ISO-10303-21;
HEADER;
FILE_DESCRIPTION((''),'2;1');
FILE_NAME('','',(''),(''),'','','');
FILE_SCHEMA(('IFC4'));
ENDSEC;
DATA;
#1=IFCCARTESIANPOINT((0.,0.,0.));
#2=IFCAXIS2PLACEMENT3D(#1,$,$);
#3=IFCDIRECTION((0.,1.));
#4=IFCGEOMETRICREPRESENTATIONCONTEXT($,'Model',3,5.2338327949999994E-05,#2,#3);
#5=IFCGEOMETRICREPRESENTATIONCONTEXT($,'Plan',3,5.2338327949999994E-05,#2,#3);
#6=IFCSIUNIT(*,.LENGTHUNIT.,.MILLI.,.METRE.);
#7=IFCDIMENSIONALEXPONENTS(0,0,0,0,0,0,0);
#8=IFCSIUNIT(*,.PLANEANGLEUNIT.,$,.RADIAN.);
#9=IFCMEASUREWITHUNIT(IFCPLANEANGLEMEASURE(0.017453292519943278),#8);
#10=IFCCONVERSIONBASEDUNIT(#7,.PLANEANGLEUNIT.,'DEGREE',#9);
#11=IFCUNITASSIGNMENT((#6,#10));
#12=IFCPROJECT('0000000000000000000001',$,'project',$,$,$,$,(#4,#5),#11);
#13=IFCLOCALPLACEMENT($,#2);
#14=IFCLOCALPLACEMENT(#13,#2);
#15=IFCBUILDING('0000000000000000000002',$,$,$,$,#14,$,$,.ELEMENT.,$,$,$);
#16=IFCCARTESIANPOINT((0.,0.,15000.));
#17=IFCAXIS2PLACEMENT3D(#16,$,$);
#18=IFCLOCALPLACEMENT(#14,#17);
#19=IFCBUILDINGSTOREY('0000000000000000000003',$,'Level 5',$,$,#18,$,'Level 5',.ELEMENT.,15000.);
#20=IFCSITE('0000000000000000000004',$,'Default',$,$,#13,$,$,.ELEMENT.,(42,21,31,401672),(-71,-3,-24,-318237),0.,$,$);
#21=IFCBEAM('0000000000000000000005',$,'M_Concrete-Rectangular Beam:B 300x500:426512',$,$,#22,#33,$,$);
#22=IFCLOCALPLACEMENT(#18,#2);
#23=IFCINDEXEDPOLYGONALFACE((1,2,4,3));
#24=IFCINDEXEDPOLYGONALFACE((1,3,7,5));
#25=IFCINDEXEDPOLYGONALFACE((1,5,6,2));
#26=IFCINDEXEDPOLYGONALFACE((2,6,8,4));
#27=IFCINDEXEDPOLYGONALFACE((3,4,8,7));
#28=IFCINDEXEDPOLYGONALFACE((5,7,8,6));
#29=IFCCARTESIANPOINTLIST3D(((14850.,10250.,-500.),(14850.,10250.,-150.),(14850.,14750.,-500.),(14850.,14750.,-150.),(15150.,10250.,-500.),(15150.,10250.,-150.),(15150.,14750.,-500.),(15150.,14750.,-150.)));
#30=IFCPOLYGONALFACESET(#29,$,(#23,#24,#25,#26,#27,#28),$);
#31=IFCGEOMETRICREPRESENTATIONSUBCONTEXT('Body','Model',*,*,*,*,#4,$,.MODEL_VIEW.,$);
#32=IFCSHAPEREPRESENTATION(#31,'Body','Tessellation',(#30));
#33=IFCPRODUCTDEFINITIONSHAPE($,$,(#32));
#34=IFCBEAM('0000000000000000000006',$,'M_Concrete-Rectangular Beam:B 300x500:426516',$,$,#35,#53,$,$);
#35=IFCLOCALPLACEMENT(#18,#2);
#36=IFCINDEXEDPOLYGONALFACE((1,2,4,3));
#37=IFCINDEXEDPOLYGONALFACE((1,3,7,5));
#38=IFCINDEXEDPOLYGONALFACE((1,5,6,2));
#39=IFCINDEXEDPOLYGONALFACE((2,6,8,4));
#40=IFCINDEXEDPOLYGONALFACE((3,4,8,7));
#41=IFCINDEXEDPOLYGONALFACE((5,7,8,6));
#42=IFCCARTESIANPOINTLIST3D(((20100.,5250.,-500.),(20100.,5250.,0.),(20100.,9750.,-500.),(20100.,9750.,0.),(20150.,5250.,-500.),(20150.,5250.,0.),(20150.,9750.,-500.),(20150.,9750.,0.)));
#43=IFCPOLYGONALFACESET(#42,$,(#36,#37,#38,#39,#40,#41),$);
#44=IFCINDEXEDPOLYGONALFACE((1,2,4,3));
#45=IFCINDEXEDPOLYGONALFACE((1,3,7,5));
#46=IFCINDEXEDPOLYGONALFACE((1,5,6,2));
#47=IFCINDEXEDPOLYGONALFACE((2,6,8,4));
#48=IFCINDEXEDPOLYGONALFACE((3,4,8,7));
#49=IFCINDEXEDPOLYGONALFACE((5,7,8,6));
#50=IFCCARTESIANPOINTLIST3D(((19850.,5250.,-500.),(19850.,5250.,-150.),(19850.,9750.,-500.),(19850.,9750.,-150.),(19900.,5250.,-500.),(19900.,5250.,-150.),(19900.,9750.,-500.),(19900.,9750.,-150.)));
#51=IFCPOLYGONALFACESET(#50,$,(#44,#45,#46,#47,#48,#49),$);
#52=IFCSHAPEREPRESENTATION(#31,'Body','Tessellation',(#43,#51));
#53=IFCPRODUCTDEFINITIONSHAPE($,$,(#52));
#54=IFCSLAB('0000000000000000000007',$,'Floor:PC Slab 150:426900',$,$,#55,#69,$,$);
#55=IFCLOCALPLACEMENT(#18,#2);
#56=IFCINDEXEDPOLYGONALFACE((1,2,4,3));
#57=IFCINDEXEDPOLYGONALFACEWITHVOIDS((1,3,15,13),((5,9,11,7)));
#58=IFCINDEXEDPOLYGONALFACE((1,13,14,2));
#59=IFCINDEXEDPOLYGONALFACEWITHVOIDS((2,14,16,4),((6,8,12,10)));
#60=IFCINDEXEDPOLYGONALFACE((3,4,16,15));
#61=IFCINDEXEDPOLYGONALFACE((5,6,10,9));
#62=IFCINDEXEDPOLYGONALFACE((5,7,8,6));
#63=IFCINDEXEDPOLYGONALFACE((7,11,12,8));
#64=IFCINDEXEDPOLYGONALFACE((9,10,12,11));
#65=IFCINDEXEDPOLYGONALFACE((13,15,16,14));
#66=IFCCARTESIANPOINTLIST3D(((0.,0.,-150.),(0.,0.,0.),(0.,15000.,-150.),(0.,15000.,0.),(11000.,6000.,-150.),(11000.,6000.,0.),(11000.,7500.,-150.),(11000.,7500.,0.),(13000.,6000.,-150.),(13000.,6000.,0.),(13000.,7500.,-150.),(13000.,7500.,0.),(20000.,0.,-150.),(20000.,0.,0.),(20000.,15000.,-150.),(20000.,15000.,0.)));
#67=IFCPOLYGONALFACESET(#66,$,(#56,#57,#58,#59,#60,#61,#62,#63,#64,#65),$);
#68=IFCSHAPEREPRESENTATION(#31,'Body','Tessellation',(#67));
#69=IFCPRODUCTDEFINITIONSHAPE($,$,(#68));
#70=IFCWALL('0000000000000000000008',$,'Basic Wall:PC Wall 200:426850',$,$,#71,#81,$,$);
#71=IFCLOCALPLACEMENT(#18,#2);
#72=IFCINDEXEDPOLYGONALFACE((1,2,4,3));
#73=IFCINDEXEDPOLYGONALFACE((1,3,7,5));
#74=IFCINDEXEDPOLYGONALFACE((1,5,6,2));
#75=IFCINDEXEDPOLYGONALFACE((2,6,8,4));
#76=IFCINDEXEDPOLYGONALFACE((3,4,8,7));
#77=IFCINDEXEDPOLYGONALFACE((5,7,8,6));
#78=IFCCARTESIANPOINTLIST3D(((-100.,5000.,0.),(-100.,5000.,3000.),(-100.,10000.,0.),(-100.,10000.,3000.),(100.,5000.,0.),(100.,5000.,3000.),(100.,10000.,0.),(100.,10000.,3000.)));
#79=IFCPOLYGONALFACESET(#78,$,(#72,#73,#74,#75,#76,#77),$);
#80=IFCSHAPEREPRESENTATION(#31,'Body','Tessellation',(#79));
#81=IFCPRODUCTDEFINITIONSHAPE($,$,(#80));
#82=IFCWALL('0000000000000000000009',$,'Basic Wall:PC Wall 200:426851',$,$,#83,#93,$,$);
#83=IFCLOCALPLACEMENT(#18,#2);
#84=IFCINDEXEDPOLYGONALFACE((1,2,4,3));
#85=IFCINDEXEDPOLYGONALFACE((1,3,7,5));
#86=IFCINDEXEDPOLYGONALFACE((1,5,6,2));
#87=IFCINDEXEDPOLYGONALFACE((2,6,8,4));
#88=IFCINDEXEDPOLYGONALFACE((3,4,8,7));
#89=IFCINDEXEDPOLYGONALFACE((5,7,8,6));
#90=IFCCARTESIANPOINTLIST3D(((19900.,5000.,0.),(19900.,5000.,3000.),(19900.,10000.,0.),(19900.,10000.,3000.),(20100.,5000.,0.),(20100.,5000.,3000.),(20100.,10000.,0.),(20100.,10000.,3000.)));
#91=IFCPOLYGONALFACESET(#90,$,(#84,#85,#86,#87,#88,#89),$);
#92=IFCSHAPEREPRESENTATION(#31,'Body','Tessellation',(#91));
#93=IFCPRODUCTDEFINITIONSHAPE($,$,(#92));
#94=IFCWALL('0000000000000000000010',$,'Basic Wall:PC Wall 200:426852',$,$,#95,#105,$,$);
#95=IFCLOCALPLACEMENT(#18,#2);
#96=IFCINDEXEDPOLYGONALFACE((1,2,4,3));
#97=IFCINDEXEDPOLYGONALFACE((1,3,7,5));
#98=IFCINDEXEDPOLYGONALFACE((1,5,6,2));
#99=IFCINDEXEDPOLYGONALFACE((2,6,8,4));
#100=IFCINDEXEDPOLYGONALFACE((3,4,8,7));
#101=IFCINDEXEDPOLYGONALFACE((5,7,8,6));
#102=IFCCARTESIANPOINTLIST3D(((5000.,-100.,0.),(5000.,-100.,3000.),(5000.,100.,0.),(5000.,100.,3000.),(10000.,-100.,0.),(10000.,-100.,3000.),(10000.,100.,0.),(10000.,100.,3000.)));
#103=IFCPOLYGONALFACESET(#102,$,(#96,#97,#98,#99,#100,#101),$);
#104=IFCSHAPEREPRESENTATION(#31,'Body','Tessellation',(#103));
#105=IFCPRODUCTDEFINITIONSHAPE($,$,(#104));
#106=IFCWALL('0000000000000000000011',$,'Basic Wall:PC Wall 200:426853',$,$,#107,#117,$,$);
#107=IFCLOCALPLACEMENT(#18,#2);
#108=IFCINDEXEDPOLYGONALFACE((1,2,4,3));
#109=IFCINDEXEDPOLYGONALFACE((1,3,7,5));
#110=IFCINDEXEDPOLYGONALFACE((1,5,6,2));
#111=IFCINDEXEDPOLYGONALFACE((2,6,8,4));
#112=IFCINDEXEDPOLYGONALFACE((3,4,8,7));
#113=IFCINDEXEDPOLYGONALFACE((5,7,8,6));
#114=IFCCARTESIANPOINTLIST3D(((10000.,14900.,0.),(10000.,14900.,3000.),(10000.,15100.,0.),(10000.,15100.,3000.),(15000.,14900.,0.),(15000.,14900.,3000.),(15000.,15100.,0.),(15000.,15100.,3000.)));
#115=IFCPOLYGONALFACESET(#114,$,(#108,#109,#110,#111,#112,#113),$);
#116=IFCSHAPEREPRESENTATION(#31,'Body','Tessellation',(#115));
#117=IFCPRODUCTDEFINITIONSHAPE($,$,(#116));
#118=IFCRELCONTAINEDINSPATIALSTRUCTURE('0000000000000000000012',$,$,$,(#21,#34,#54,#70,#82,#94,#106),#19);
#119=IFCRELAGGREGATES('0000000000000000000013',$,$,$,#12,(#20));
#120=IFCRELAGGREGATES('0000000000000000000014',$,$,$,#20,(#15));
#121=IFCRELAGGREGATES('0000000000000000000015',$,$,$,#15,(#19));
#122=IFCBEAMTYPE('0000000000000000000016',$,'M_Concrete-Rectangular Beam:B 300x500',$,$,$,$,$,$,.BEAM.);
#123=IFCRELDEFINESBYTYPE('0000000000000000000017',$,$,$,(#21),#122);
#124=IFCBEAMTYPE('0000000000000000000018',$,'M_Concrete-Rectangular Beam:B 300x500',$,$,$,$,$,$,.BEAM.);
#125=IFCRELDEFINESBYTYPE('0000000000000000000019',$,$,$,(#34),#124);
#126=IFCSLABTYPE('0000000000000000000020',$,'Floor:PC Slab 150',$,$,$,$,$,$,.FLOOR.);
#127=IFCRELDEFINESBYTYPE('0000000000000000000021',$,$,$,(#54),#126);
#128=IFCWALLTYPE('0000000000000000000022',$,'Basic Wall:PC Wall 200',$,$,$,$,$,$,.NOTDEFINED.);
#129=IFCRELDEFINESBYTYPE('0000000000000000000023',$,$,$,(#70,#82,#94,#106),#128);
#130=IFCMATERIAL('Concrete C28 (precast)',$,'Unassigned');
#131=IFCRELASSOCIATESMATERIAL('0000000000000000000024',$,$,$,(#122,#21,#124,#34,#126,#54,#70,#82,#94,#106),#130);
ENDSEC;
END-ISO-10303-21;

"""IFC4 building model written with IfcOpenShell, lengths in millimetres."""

from ifc_helpers import new_model, entity, si_unit, converted_unit, direction, frame, origin, place, context, subcontext, project, spatial, indexed_curve, outline, extrude, source, transform, mapped, material, type_object, type_shapes, element, save


model = new_model("IFC4")

# Units and contexts
model_context = context("Model", 3, precision=5.2338327949999994e-05, world=origin(), true_north=direction((0.0, 1.0)))
plan_context = context("Plan", 3, precision=5.2338327949999994e-05, world=origin(), true_north=direction((0.0, 1.0)))
body_context = subcontext(model_context, "Body", "Model", "MODEL_VIEW")
ifc_project = project(units=[si_unit("LENGTHUNIT", "METRE", prefix="MILLI"), converted_unit("PLANEANGLEUNIT", "DEGREE", entity("IfcPlaneAngleMeasure", 0.017453292519943278), si_unit("PLANEANGLEUNIT", "RADIAN"), dimensions=[0, 0, 0, 0, 0, 0, 0])], contexts=[model_context, plan_context])

# Site, building, storey
site_placement = place(None, origin())
site = spatial("IfcSite", under=ifc_project, at=site_placement, Name="Default", CompositionType="ELEMENT", RefLatitude=(42, 21, 31, 401672), RefLongitude=(-71, -3, -24, -318237), RefElevation=0.0)
building_placement = place(site_placement, origin())
building = spatial("IfcBuilding", under=site, at=building_placement, CompositionType="ELEMENT")
storey_placement = place(building_placement, frame((0.0, 0.0, 15000.0)))
storey = spatial("IfcBuildingStorey", under=building, at=storey_placement, Name="Level 5", LongName="Level 5", CompositionType="ELEMENT", Elevation=15000.0)

# Beams
ifc_material = material(Name="Concrete C28 (precast)", Category="Unassigned")
beam_type_1 = type_object("IfcBeamType", Name="M_Concrete-Rectangular Beam:B 300x500", PredefinedType="BEAM", material=ifc_material)
shared_shape_1 = source(origin(), body_context, "Body", "SweptSolid", [
    extrude(outline(indexed_curve([(-150.0, -175.0), (150.0, -175.0), (150.0, 175.0), (-150.0, 175.0), (-150.0, -175.0)], self_intersect=False)), frame((15000.0, 10250.0, 14675.0), z_axis=(0.0, 1.0, 0.0), x_axis=(-1.0, 0.0, 0.0)), (0.0, 0.0, 1.0), 4500.0),
])
type_shapes(beam_type_1, [shared_shape_1])
beam_1_placement = place(storey_placement, frame((0.0, 0.0, -15000.0)))
element("IfcBeam", 1, at=beam_1_placement, inside=storey, type_object=beam_type_1, material=ifc_material, Name="M_Concrete-Rectangular Beam:B 300x500:426512", context=body_context, shape_type="MappedRepresentation", body=[
    mapped(shared_shape_1, transform((0.0, 0.0, 0.0), scale=1.0)),
])
beam_type_2 = type_object("IfcBeamType", Name="M_Concrete-Rectangular Beam:B 300x500", PredefinedType="BEAM", material=ifc_material)
shared_shape_2 = source(origin(), body_context, "Body", "SweptSolid", [
    extrude(outline(indexed_curve([(-25.0, -250.0), (25.0, -250.0), (25.0, 250.0), (-25.0, 250.0), (-25.0, -250.0)], self_intersect=False)), frame((20125.0, 5250.0, 14750.0), z_axis=(0.0, 1.0, 0.0), x_axis=(-1.0, 0.0, 0.0)), (0.0, 0.0, 1.0), 4500.0),
    extrude(outline(indexed_curve([(-25.0, -175.0), (25.0, -175.0), (25.0, 175.0), (-25.0, 175.0), (-25.0, -175.0)], self_intersect=False)), frame((19875.0, 5250.0, 14675.0), z_axis=(0.0, 1.0, 0.0), x_axis=(-1.0, 0.0, 0.0)), (0.0, 0.0, 1.0), 4500.0),
])
type_shapes(beam_type_2, [shared_shape_2])
beam_2_placement = place(storey_placement, frame((0.0, 0.0, -15000.0)))
element("IfcBeam", 2, at=beam_2_placement, inside=storey, type_object=beam_type_2, material=ifc_material, Name="M_Concrete-Rectangular Beam:B 300x500:426516", context=body_context, shape_type="MappedRepresentation", body=[
    mapped(shared_shape_2, transform((0.0, 0.0, 0.0), scale=1.0)),
])

# Slab, opening
slab_type = type_object("IfcSlabType", Name="Floor:PC Slab 150", PredefinedType="FLOOR", material=ifc_material)
slab_placement = place(storey_placement, origin())
slab = element("IfcSlab", 3, at=slab_placement, inside=storey, type_object=slab_type, material=ifc_material, Name="Floor:PC Slab 150:426900", context=body_context, shape_type="SweptSolid", body=[
    extrude(outline(indexed_curve([(-7500.0, -10000.0), (7500.0, -10000.0), (7500.0, 10000.0), (-7500.0, 10000.0), (-7500.0, -10000.0)], self_intersect=False), holes=[indexed_curve([(-1500.0, -3000.0), (-1500.0, -1000.0), (0.0, -1000.0), (0.0, -3000.0), (-1500.0, -3000.0)], self_intersect=False)]), frame((10000.0, 7500.0, -150.0), z_axis=(0.0, 0.0, 1.0), x_axis=(0.0, 1.0, 0.0)), (0.0, 0.0, 1.0), 150.0),
])
opening_placement = place(slab_placement, origin())
element("IfcOpeningElement", 4, at=opening_placement, cuts=slab, PredefinedType="OPENING", context=body_context, shape_type="SweptSolid", body=[
    extrude(outline(indexed_curve([(13000.0, 6000.0), (13000.0, 7500.0), (11000.0, 7500.0), (11000.0, 6000.0), (13000.0, 6000.0)], self_intersect=False)), frame((0.0, 0.0, -15000.0)), (0.0, 0.0, 1.0), 20000.0),
])

# Walls
wall_type = type_object("IfcWallType", Name="Basic Wall:PC Wall 200", PredefinedType="NOTDEFINED")
wall_1_placement = place(storey_placement, frame((0.0, 5000.0, 0.0), z_axis=(0.0, 0.0, 1.0), x_axis=(0.0, 1.0, 0.0)))
element("IfcWall", 5, at=wall_1_placement, inside=storey, type_object=wall_type, material=ifc_material, Name="Basic Wall:PC Wall 200:426850", context=body_context, shape_type="SweptSolid", body=[
    extrude(outline(indexed_curve([(5000.0, 100.0), (0.0, 100.0), (0.0, -100.0), (5000.0, -100.0), (5000.0, 100.0)], self_intersect=False)), origin(), (0.0, 0.0, 1.0), 3000.0),
])
wall_2_placement = place(storey_placement, frame((20000.0, 5000.0, 0.0), z_axis=(0.0, 0.0, 1.0), x_axis=(0.0, 1.0, 0.0)))
element("IfcWall", 6, at=wall_2_placement, inside=storey, type_object=wall_type, material=ifc_material, Name="Basic Wall:PC Wall 200:426851", context=body_context, shape_type="SweptSolid", body=[
    extrude(outline(indexed_curve([(5000.0, 100.0), (0.0, 100.0), (0.0, -100.0), (5000.0, -100.0), (5000.0, 100.0)], self_intersect=False)), origin(), (0.0, 0.0, 1.0), 3000.0),
])
wall_3_placement = place(storey_placement, frame((5000.0, 0.0, 0.0)))
element("IfcWall", 7, at=wall_3_placement, inside=storey, type_object=wall_type, material=ifc_material, Name="Basic Wall:PC Wall 200:426852", context=body_context, shape_type="SweptSolid", body=[
    extrude(outline(indexed_curve([(5000.0, 100.0), (0.0, 100.0), (0.0, -100.0), (5000.0, -100.0), (5000.0, 100.0)], self_intersect=False)), origin(), (0.0, 0.0, 1.0), 3000.0),
])
wall_4_placement = place(storey_placement, frame((10000.0, 15000.0, 0.0)))
element("IfcWall", 8, at=wall_4_placement, inside=storey, type_object=wall_type, material=ifc_material, Name="Basic Wall:PC Wall 200:426853", context=body_context, shape_type="SweptSolid", body=[
    extrude(outline(indexed_curve([(5000.0, 100.0), (0.0, 100.0), (0.0, -100.0), (5000.0, -100.0), (5000.0, 100.0)], self_intersect=False)), origin(), (0.0, 0.0, 1.0), 3000.0),
])

save(model, "model.ifc")
